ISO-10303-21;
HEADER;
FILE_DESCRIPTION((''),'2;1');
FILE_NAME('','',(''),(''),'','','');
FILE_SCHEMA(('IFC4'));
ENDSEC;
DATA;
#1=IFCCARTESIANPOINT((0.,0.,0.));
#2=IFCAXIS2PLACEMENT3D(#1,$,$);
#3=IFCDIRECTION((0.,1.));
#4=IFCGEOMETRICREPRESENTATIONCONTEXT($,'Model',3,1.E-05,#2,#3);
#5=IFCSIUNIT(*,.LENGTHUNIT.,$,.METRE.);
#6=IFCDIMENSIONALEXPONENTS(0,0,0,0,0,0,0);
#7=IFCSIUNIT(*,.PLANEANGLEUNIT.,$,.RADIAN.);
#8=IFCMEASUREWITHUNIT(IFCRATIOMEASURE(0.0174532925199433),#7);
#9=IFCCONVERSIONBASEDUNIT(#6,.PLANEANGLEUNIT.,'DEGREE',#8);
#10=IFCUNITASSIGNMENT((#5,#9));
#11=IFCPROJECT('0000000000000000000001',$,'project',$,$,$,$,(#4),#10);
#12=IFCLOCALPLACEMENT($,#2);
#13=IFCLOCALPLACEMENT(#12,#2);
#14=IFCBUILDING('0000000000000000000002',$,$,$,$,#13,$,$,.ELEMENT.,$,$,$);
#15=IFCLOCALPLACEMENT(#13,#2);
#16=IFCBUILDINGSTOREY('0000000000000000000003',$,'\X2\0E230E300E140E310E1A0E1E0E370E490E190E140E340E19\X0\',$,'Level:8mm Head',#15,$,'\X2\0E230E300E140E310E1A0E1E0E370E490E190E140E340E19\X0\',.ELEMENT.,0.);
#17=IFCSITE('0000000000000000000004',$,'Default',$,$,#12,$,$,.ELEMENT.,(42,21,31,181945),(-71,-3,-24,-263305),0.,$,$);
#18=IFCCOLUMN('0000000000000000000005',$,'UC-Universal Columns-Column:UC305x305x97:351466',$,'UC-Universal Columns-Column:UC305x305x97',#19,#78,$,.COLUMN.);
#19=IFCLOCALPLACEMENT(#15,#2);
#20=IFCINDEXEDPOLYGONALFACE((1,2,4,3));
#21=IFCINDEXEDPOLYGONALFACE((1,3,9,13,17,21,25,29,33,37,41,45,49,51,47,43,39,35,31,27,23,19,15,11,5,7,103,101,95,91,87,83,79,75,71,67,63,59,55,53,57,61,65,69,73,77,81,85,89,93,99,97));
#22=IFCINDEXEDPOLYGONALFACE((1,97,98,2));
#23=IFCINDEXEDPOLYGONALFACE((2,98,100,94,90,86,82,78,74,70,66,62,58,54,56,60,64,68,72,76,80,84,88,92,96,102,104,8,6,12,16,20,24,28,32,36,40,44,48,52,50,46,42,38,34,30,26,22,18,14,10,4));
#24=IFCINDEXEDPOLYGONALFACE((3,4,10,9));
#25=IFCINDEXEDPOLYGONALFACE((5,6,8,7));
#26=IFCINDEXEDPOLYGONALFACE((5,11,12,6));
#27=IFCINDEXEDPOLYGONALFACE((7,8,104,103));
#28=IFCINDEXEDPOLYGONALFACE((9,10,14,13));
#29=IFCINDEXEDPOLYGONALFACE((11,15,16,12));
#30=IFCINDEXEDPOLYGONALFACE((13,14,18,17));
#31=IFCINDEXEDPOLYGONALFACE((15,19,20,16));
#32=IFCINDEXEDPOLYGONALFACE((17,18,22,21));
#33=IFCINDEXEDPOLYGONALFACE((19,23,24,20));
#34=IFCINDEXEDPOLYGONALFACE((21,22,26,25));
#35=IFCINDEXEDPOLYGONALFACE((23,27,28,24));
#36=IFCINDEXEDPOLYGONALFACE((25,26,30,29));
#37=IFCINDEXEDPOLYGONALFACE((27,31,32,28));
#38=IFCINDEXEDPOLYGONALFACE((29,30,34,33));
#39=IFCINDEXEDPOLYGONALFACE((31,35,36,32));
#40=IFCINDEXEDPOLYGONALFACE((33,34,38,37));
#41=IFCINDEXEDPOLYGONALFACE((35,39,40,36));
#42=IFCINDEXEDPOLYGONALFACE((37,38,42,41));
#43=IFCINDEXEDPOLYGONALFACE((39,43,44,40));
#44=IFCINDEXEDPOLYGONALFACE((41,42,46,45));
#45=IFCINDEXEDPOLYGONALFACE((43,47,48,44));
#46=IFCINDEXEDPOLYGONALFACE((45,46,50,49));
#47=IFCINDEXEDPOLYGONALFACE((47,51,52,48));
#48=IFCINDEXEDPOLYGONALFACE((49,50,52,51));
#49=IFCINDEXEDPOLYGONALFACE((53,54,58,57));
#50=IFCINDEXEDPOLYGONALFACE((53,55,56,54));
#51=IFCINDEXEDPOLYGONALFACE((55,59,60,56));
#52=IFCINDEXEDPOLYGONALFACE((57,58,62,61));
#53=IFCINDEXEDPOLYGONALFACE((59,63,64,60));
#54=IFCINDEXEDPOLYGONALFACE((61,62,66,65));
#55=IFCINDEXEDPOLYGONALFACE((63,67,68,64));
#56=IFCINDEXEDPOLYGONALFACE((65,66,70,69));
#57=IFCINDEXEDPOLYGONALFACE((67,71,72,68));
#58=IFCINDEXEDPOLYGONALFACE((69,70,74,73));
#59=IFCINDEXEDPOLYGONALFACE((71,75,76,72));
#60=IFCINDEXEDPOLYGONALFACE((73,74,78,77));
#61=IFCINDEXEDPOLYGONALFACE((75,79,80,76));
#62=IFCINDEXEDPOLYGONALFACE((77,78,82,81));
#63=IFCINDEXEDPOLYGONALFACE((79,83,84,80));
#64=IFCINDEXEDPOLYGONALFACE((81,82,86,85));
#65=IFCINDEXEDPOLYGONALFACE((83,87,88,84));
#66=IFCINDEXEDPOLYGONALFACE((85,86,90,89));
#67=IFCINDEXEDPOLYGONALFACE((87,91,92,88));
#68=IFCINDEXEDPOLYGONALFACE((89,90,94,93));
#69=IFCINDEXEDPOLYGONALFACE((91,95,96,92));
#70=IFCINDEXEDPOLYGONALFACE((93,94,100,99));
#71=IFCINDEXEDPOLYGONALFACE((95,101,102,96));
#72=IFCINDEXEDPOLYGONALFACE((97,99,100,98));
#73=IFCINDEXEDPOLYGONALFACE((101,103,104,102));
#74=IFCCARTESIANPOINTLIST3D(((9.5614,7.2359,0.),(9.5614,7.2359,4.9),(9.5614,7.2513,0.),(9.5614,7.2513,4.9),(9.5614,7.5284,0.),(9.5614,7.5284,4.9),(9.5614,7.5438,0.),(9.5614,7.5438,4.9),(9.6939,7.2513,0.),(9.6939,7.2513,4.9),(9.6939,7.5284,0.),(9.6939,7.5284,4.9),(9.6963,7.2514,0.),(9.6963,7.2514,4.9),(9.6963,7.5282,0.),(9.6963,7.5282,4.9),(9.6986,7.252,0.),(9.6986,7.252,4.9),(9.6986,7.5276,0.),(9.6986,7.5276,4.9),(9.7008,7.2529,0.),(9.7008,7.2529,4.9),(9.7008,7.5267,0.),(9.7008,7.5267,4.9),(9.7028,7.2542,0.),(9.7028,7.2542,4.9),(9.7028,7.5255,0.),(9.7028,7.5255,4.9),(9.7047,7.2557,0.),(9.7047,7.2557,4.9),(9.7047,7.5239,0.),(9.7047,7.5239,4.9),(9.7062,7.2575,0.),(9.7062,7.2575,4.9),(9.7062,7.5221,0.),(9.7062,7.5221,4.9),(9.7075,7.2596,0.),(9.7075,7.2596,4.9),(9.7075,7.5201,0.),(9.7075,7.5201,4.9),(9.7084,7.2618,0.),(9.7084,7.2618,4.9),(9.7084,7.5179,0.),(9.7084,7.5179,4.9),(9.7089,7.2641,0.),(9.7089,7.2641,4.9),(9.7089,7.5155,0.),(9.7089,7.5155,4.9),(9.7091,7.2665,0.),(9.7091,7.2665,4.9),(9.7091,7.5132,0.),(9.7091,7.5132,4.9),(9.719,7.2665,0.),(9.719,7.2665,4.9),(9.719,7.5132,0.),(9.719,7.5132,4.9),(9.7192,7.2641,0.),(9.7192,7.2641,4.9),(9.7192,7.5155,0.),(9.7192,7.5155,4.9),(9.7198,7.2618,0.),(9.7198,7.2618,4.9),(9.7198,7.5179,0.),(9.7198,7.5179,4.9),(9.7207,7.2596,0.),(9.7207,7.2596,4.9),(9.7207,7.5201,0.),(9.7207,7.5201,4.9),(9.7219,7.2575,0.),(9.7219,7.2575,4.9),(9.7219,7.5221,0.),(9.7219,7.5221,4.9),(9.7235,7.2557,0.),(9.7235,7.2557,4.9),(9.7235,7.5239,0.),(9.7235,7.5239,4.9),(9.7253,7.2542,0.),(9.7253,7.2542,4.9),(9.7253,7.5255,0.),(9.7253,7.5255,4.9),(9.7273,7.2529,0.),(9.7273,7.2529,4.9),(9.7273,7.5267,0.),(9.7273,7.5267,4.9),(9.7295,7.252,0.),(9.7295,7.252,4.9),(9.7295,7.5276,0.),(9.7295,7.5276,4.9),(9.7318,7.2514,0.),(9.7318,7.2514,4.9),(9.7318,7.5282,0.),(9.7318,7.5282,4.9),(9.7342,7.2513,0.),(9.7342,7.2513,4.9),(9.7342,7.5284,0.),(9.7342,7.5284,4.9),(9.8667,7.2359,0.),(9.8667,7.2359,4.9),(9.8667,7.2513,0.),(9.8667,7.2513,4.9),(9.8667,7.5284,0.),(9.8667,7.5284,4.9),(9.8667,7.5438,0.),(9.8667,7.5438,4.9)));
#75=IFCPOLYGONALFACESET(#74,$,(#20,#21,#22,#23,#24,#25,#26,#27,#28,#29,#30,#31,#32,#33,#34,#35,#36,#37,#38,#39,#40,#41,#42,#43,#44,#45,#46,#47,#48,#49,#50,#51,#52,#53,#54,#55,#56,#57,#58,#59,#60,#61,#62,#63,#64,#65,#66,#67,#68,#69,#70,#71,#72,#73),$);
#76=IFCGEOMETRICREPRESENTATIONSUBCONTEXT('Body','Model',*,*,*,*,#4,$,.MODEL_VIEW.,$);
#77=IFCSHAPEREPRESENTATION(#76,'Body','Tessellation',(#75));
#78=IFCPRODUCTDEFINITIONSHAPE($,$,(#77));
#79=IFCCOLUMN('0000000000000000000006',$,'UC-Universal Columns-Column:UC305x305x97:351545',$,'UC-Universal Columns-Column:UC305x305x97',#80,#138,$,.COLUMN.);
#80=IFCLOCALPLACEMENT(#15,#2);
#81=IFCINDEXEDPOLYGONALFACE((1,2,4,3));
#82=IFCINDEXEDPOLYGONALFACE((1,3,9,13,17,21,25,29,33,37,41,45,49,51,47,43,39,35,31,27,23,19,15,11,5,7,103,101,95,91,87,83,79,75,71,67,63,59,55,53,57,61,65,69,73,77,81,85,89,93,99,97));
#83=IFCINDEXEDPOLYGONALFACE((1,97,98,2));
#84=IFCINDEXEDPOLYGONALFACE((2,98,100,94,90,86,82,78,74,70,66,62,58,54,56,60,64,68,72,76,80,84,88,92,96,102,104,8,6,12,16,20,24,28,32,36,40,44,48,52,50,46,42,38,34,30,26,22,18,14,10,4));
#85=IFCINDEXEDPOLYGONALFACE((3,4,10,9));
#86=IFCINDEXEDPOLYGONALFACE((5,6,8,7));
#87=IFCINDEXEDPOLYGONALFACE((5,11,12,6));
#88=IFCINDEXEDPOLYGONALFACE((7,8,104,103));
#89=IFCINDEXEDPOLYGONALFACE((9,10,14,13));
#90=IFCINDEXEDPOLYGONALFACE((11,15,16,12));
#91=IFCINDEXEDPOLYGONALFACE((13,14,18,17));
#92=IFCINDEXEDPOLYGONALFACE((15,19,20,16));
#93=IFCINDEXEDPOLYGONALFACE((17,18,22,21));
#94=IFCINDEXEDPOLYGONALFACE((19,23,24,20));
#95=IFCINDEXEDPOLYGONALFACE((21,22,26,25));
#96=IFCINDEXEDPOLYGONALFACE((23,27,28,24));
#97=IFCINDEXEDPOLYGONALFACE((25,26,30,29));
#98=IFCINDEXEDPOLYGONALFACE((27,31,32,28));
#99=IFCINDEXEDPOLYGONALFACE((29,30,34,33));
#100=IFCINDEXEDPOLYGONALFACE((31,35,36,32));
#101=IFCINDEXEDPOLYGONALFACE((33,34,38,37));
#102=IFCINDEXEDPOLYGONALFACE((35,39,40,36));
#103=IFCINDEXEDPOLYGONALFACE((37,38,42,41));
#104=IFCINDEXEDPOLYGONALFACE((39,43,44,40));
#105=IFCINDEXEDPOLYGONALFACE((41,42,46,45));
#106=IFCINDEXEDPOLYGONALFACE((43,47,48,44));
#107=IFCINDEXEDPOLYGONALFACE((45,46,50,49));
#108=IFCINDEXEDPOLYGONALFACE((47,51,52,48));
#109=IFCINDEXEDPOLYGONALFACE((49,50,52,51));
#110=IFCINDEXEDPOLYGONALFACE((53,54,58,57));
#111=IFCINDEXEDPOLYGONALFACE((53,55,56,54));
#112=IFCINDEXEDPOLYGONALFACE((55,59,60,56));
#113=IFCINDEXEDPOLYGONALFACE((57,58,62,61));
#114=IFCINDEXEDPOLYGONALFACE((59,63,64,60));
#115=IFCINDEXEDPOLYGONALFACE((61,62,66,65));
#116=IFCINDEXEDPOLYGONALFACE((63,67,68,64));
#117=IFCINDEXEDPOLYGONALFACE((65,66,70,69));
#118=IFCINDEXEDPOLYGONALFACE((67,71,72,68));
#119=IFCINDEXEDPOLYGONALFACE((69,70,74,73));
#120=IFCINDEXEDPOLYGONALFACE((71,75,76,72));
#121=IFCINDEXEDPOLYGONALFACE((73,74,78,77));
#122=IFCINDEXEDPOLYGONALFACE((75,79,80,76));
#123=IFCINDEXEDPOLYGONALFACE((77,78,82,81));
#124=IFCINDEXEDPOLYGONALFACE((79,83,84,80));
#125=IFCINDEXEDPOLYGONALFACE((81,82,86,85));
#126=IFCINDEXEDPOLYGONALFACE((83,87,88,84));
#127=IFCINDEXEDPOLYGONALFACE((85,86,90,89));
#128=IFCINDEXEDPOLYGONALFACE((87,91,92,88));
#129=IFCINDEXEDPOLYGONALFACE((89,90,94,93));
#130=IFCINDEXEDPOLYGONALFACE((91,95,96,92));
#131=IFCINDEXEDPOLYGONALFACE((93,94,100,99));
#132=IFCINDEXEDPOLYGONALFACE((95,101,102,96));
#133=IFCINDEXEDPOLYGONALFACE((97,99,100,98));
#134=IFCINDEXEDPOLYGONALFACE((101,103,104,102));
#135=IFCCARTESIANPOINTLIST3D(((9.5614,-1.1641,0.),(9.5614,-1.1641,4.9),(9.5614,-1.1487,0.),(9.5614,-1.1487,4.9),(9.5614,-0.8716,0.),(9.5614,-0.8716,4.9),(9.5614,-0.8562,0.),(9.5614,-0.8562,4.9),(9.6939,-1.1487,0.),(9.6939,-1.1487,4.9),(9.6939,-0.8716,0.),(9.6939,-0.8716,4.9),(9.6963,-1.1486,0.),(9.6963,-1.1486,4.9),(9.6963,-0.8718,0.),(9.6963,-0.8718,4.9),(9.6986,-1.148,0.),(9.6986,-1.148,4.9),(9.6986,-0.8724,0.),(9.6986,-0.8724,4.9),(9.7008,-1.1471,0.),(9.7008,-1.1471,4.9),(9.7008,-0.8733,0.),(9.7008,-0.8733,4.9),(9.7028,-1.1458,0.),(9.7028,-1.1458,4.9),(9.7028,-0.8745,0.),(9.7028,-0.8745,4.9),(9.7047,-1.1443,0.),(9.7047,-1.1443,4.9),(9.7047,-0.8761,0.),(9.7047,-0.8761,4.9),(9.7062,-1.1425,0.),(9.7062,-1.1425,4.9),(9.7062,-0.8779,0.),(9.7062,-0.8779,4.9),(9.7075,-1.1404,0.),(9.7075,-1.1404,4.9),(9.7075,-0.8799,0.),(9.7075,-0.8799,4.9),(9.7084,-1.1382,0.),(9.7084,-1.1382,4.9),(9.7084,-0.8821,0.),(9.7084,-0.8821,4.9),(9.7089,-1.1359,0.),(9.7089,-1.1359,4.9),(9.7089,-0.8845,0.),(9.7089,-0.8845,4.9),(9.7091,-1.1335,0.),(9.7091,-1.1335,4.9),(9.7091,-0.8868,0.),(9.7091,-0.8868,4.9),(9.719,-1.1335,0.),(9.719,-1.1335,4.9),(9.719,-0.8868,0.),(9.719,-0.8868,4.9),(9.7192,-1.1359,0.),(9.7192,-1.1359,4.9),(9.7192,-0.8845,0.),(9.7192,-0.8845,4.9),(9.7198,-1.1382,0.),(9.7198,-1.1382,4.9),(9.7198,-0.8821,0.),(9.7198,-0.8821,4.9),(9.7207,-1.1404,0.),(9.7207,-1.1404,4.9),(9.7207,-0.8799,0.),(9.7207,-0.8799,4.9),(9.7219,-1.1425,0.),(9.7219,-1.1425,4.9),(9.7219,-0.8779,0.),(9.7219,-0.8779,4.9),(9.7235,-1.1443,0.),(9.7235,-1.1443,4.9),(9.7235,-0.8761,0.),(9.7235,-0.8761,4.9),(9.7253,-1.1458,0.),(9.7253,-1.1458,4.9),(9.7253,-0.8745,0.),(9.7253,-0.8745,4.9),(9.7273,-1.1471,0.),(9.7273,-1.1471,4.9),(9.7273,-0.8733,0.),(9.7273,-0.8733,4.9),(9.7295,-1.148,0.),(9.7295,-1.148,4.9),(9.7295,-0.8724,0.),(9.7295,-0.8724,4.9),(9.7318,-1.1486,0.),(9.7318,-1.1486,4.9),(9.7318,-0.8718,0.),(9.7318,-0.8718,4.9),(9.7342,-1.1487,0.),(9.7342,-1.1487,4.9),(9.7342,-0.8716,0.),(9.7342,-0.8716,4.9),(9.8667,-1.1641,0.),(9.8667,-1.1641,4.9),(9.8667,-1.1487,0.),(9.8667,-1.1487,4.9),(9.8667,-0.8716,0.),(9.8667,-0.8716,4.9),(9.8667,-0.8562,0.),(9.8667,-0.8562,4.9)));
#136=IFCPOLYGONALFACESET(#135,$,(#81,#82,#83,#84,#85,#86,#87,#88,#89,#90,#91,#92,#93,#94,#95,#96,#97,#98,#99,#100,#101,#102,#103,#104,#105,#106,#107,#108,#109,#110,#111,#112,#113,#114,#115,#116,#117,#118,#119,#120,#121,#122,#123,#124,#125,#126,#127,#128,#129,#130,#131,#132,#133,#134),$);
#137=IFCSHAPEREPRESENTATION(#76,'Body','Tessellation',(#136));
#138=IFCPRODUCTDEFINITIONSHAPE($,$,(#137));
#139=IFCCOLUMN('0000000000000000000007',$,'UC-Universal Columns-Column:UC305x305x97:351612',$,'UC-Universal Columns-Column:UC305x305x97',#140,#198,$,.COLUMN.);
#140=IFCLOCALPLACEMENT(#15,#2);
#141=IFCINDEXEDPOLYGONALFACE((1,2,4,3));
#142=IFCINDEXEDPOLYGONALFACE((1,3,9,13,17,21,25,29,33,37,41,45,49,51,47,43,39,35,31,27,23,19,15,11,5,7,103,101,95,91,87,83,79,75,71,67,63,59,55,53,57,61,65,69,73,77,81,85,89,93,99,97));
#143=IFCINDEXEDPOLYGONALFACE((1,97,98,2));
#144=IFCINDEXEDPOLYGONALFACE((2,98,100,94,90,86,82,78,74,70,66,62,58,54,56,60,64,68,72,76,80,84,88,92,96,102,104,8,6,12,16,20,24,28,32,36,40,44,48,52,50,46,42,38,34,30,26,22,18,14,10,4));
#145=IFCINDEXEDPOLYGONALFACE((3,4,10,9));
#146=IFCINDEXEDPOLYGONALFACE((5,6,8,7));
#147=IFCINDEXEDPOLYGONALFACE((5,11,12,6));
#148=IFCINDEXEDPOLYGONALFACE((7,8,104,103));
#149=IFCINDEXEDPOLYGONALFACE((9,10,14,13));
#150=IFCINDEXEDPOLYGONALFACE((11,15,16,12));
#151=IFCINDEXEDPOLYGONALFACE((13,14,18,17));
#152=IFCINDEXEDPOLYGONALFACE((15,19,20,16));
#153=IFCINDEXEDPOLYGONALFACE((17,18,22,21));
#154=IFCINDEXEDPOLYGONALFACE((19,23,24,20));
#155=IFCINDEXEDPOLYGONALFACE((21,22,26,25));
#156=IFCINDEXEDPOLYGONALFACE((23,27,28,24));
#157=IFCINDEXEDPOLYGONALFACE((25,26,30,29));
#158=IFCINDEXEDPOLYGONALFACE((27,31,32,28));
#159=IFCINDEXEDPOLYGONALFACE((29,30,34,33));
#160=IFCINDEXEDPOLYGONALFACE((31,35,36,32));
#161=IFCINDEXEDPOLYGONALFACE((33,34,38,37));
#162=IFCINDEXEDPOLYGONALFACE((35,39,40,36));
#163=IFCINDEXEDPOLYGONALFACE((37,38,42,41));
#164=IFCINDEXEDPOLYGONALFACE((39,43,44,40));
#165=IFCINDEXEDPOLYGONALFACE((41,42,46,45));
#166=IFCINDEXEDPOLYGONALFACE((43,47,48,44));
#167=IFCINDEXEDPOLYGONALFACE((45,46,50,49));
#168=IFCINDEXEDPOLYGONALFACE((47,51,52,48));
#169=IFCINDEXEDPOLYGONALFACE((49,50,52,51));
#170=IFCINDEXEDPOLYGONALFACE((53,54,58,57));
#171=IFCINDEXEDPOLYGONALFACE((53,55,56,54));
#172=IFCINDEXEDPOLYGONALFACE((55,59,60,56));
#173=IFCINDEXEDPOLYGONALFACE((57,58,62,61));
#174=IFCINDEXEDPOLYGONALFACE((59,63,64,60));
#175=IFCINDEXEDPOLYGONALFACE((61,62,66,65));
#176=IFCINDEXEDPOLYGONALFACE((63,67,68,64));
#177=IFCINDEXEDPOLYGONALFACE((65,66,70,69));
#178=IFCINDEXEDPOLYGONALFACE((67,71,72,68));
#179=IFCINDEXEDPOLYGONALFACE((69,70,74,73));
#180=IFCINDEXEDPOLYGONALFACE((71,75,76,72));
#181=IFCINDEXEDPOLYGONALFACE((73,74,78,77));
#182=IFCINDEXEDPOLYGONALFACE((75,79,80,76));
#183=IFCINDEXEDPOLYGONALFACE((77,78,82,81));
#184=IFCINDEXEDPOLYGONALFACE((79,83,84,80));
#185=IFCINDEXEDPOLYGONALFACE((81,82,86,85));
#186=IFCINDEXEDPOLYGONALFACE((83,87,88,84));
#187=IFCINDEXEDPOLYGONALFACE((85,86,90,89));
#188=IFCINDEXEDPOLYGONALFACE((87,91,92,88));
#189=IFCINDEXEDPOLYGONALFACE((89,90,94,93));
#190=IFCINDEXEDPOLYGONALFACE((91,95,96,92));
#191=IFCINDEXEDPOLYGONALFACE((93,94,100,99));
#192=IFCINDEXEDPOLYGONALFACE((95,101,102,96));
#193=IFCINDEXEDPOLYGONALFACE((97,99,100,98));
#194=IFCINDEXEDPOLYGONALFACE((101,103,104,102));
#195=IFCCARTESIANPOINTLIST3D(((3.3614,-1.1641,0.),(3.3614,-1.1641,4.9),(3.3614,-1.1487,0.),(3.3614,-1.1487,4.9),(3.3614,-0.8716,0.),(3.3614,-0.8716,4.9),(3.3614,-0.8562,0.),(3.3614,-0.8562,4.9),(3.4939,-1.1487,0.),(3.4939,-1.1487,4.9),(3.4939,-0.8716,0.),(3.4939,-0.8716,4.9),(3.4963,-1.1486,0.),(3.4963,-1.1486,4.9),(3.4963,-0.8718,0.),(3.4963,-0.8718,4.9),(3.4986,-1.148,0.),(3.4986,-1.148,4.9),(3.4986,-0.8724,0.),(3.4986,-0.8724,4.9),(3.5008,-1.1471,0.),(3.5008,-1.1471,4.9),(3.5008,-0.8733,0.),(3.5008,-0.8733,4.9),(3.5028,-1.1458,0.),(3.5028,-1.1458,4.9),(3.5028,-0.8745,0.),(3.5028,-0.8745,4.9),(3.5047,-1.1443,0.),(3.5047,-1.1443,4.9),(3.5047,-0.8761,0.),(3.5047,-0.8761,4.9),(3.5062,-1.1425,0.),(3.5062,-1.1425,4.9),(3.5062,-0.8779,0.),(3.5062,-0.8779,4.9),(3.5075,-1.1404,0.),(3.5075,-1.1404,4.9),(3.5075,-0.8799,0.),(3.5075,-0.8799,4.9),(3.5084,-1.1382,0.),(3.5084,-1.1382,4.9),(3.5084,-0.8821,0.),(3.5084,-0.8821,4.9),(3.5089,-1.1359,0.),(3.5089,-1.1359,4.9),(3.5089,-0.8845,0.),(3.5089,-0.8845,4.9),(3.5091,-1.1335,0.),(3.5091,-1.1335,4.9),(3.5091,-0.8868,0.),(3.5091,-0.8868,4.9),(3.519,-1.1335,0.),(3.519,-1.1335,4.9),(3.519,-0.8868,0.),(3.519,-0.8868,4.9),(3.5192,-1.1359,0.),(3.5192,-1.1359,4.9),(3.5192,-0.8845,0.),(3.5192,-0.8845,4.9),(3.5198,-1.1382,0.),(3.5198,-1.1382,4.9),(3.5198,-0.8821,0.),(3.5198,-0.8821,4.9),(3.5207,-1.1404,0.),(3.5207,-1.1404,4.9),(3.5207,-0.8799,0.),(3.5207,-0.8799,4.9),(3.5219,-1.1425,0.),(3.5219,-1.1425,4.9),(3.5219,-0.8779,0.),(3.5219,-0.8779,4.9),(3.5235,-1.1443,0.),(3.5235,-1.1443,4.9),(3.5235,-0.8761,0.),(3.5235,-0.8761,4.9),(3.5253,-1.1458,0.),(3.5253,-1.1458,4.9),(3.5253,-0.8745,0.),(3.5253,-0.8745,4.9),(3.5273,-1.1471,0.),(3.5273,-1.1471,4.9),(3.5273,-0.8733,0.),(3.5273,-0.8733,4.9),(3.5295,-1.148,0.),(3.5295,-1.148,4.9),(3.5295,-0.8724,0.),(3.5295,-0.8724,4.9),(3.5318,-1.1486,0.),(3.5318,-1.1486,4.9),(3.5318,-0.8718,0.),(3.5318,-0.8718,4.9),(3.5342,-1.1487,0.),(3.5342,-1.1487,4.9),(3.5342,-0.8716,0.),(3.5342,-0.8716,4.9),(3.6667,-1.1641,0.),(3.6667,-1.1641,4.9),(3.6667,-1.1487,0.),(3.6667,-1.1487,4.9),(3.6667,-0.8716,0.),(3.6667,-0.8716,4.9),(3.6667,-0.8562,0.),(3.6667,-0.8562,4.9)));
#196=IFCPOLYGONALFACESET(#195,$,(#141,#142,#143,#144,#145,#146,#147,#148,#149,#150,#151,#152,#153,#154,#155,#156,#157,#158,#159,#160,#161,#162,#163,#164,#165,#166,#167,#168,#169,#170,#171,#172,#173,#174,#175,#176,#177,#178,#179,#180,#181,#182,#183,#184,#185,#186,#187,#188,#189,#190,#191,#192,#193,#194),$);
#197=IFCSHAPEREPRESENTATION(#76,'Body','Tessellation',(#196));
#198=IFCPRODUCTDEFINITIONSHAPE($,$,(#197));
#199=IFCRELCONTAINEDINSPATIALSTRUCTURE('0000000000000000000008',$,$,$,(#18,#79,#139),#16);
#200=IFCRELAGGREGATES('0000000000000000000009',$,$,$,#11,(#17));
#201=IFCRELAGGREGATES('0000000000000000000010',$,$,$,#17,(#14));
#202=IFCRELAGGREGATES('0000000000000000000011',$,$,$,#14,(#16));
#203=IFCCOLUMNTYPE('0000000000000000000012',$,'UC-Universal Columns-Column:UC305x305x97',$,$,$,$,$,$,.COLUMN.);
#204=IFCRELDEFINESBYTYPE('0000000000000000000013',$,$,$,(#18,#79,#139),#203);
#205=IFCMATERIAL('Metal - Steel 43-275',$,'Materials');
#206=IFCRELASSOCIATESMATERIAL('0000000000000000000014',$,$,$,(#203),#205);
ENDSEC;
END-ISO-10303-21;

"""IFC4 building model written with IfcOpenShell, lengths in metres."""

from ifc_helpers import new_model, entity, si_unit, converted_unit, direction, frame, origin, place, context, subcontext, project, spatial, indexed_curve, outline, extrude, source, transform, mapped, material, type_object, type_shapes, element, save


model = new_model("IFC4")

# Units and contexts
model_context = context("Model", 3, precision=1e-05, world=origin(), true_north=direction((0.0, 1.0)))
body_context = subcontext(model_context, "Body", "Model", "MODEL_VIEW")
ifc_project = project(units=[si_unit("LENGTHUNIT", "METRE"), converted_unit("PLANEANGLEUNIT", "DEGREE", entity("IfcRatioMeasure", 0.0174532925199433), si_unit("PLANEANGLEUNIT", "RADIAN"), dimensions=[0, 0, 0, 0, 0, 0, 0])], contexts=[model_context])

# Site, building, storey
site_placement = place(None, origin())
site = spatial("IfcSite", under=ifc_project, at=site_placement, Name="Default", CompositionType="ELEMENT", RefLatitude=(42, 21, 31, 181945), RefLongitude=(-71, -3, -24, -263305), RefElevation=0.0)
building_placement = place(site_placement, origin())
building = spatial("IfcBuilding", under=site, at=building_placement, CompositionType="ELEMENT")
storey_placement = place(building_placement, origin())
storey = spatial("IfcBuildingStorey", under=building, at=storey_placement, Name="ระดับพื้นดิน", ObjectType="Level:8mm Head", LongName="ระดับพื้นดิน", CompositionType="ELEMENT", Elevation=0.0)

# Columns
ifc_material_1 = material(Name="Metal - Steel 43-275", Category="Materials")
column_type_1 = type_object("IfcColumnType", Name="UC-Universal Columns-Column:UC305x305x97", PredefinedType="COLUMN", material=ifc_material_1)
shared_shape_1 = source(origin(), body_context, "Body", "SweptSolid", [
    extrude(outline(indexed_curve([(-0.154, -0.1527), (-0.1386, -0.1527), (-0.1386, -0.0202), (-0.1384, -0.0178), (-0.1378, -0.0155), (-0.1369, -0.0132), (-0.1356, -0.0112), (-0.1341, -0.0094), (-0.1323, -0.0079), (-0.1303, -0.0066), (-0.128, -0.0057), (-0.1257, -0.0051), (-0.1234, -0.0049), (0.1234, -0.0049), (0.1257, -0.0051), (0.128, -0.0057), (0.1303, -0.0066), (0.1323, -0.0079), (0.1341, -0.0094), (0.1356, -0.0112), (0.1369, -0.0132), (0.1378, -0.0155), (0.1384, -0.0178), (0.1386, -0.0201), (0.1386, -0.1527), (0.154, -0.1527), (0.154, 0.1527), (0.1386, 0.1527), (0.1386, 0.0202), (0.1384, 0.0178), (0.1378, 0.0155), (0.1369, 0.0132), (0.1356, 0.0112), (0.1341, 0.0094), (0.1323, 0.0079), (0.1303, 0.0066), (0.128, 0.0057), (0.1257, 0.0051), (0.1234, 0.005), (-0.1234, 0.005), (-0.1257, 0.0051), (-0.128, 0.0057), (-0.1303, 0.0066), (-0.1323, 0.0079), (-0.1341, 0.0094), (-0.1356, 0.0112), (-0.1369, 0.0132), (-0.1378, 0.0155), (-0.1384, 0.0178), (-0.1386, 0.0202), (-0.1386, 0.1527), (-0.154, 0.1527), (-0.154, -0.1527)], self_intersect=False)), frame((0.0, 0.0, 0.0), z_axis=(0.0, 0.0, 1.0), x_axis=(0.0, -1.0, 0.0)), (0.0, 0.0, 1.0), 4.9),
])
type_shapes(column_type_1, [shared_shape_1])
for number, where, name in (
    (1, (9.7141, 7.3898, 0.0), "UC-Universal Columns-Column:UC305x305x97:351466"),
    (2, (9.7141, -1.0102, 0.0), "UC-Universal Columns-Column:UC305x305x97:351545"),
    (3, (3.5141, -1.0102, 0.0), "UC-Universal Columns-Column:UC305x305x97:351612"),
):
    element("IfcColumn", number, at=place(storey_placement, frame(where)), inside=storey, type_object=column_type_1, Name=name, ObjectType="UC-Universal Columns-Column:UC305x305x97", PredefinedType="COLUMN", context=body_context, shape_type="MappedRepresentation", body=[
        mapped(shared_shape_1, transform((0.0, 0.0, 0.0), scale=1.0)),
    ])

save(model, "model.ifc")
